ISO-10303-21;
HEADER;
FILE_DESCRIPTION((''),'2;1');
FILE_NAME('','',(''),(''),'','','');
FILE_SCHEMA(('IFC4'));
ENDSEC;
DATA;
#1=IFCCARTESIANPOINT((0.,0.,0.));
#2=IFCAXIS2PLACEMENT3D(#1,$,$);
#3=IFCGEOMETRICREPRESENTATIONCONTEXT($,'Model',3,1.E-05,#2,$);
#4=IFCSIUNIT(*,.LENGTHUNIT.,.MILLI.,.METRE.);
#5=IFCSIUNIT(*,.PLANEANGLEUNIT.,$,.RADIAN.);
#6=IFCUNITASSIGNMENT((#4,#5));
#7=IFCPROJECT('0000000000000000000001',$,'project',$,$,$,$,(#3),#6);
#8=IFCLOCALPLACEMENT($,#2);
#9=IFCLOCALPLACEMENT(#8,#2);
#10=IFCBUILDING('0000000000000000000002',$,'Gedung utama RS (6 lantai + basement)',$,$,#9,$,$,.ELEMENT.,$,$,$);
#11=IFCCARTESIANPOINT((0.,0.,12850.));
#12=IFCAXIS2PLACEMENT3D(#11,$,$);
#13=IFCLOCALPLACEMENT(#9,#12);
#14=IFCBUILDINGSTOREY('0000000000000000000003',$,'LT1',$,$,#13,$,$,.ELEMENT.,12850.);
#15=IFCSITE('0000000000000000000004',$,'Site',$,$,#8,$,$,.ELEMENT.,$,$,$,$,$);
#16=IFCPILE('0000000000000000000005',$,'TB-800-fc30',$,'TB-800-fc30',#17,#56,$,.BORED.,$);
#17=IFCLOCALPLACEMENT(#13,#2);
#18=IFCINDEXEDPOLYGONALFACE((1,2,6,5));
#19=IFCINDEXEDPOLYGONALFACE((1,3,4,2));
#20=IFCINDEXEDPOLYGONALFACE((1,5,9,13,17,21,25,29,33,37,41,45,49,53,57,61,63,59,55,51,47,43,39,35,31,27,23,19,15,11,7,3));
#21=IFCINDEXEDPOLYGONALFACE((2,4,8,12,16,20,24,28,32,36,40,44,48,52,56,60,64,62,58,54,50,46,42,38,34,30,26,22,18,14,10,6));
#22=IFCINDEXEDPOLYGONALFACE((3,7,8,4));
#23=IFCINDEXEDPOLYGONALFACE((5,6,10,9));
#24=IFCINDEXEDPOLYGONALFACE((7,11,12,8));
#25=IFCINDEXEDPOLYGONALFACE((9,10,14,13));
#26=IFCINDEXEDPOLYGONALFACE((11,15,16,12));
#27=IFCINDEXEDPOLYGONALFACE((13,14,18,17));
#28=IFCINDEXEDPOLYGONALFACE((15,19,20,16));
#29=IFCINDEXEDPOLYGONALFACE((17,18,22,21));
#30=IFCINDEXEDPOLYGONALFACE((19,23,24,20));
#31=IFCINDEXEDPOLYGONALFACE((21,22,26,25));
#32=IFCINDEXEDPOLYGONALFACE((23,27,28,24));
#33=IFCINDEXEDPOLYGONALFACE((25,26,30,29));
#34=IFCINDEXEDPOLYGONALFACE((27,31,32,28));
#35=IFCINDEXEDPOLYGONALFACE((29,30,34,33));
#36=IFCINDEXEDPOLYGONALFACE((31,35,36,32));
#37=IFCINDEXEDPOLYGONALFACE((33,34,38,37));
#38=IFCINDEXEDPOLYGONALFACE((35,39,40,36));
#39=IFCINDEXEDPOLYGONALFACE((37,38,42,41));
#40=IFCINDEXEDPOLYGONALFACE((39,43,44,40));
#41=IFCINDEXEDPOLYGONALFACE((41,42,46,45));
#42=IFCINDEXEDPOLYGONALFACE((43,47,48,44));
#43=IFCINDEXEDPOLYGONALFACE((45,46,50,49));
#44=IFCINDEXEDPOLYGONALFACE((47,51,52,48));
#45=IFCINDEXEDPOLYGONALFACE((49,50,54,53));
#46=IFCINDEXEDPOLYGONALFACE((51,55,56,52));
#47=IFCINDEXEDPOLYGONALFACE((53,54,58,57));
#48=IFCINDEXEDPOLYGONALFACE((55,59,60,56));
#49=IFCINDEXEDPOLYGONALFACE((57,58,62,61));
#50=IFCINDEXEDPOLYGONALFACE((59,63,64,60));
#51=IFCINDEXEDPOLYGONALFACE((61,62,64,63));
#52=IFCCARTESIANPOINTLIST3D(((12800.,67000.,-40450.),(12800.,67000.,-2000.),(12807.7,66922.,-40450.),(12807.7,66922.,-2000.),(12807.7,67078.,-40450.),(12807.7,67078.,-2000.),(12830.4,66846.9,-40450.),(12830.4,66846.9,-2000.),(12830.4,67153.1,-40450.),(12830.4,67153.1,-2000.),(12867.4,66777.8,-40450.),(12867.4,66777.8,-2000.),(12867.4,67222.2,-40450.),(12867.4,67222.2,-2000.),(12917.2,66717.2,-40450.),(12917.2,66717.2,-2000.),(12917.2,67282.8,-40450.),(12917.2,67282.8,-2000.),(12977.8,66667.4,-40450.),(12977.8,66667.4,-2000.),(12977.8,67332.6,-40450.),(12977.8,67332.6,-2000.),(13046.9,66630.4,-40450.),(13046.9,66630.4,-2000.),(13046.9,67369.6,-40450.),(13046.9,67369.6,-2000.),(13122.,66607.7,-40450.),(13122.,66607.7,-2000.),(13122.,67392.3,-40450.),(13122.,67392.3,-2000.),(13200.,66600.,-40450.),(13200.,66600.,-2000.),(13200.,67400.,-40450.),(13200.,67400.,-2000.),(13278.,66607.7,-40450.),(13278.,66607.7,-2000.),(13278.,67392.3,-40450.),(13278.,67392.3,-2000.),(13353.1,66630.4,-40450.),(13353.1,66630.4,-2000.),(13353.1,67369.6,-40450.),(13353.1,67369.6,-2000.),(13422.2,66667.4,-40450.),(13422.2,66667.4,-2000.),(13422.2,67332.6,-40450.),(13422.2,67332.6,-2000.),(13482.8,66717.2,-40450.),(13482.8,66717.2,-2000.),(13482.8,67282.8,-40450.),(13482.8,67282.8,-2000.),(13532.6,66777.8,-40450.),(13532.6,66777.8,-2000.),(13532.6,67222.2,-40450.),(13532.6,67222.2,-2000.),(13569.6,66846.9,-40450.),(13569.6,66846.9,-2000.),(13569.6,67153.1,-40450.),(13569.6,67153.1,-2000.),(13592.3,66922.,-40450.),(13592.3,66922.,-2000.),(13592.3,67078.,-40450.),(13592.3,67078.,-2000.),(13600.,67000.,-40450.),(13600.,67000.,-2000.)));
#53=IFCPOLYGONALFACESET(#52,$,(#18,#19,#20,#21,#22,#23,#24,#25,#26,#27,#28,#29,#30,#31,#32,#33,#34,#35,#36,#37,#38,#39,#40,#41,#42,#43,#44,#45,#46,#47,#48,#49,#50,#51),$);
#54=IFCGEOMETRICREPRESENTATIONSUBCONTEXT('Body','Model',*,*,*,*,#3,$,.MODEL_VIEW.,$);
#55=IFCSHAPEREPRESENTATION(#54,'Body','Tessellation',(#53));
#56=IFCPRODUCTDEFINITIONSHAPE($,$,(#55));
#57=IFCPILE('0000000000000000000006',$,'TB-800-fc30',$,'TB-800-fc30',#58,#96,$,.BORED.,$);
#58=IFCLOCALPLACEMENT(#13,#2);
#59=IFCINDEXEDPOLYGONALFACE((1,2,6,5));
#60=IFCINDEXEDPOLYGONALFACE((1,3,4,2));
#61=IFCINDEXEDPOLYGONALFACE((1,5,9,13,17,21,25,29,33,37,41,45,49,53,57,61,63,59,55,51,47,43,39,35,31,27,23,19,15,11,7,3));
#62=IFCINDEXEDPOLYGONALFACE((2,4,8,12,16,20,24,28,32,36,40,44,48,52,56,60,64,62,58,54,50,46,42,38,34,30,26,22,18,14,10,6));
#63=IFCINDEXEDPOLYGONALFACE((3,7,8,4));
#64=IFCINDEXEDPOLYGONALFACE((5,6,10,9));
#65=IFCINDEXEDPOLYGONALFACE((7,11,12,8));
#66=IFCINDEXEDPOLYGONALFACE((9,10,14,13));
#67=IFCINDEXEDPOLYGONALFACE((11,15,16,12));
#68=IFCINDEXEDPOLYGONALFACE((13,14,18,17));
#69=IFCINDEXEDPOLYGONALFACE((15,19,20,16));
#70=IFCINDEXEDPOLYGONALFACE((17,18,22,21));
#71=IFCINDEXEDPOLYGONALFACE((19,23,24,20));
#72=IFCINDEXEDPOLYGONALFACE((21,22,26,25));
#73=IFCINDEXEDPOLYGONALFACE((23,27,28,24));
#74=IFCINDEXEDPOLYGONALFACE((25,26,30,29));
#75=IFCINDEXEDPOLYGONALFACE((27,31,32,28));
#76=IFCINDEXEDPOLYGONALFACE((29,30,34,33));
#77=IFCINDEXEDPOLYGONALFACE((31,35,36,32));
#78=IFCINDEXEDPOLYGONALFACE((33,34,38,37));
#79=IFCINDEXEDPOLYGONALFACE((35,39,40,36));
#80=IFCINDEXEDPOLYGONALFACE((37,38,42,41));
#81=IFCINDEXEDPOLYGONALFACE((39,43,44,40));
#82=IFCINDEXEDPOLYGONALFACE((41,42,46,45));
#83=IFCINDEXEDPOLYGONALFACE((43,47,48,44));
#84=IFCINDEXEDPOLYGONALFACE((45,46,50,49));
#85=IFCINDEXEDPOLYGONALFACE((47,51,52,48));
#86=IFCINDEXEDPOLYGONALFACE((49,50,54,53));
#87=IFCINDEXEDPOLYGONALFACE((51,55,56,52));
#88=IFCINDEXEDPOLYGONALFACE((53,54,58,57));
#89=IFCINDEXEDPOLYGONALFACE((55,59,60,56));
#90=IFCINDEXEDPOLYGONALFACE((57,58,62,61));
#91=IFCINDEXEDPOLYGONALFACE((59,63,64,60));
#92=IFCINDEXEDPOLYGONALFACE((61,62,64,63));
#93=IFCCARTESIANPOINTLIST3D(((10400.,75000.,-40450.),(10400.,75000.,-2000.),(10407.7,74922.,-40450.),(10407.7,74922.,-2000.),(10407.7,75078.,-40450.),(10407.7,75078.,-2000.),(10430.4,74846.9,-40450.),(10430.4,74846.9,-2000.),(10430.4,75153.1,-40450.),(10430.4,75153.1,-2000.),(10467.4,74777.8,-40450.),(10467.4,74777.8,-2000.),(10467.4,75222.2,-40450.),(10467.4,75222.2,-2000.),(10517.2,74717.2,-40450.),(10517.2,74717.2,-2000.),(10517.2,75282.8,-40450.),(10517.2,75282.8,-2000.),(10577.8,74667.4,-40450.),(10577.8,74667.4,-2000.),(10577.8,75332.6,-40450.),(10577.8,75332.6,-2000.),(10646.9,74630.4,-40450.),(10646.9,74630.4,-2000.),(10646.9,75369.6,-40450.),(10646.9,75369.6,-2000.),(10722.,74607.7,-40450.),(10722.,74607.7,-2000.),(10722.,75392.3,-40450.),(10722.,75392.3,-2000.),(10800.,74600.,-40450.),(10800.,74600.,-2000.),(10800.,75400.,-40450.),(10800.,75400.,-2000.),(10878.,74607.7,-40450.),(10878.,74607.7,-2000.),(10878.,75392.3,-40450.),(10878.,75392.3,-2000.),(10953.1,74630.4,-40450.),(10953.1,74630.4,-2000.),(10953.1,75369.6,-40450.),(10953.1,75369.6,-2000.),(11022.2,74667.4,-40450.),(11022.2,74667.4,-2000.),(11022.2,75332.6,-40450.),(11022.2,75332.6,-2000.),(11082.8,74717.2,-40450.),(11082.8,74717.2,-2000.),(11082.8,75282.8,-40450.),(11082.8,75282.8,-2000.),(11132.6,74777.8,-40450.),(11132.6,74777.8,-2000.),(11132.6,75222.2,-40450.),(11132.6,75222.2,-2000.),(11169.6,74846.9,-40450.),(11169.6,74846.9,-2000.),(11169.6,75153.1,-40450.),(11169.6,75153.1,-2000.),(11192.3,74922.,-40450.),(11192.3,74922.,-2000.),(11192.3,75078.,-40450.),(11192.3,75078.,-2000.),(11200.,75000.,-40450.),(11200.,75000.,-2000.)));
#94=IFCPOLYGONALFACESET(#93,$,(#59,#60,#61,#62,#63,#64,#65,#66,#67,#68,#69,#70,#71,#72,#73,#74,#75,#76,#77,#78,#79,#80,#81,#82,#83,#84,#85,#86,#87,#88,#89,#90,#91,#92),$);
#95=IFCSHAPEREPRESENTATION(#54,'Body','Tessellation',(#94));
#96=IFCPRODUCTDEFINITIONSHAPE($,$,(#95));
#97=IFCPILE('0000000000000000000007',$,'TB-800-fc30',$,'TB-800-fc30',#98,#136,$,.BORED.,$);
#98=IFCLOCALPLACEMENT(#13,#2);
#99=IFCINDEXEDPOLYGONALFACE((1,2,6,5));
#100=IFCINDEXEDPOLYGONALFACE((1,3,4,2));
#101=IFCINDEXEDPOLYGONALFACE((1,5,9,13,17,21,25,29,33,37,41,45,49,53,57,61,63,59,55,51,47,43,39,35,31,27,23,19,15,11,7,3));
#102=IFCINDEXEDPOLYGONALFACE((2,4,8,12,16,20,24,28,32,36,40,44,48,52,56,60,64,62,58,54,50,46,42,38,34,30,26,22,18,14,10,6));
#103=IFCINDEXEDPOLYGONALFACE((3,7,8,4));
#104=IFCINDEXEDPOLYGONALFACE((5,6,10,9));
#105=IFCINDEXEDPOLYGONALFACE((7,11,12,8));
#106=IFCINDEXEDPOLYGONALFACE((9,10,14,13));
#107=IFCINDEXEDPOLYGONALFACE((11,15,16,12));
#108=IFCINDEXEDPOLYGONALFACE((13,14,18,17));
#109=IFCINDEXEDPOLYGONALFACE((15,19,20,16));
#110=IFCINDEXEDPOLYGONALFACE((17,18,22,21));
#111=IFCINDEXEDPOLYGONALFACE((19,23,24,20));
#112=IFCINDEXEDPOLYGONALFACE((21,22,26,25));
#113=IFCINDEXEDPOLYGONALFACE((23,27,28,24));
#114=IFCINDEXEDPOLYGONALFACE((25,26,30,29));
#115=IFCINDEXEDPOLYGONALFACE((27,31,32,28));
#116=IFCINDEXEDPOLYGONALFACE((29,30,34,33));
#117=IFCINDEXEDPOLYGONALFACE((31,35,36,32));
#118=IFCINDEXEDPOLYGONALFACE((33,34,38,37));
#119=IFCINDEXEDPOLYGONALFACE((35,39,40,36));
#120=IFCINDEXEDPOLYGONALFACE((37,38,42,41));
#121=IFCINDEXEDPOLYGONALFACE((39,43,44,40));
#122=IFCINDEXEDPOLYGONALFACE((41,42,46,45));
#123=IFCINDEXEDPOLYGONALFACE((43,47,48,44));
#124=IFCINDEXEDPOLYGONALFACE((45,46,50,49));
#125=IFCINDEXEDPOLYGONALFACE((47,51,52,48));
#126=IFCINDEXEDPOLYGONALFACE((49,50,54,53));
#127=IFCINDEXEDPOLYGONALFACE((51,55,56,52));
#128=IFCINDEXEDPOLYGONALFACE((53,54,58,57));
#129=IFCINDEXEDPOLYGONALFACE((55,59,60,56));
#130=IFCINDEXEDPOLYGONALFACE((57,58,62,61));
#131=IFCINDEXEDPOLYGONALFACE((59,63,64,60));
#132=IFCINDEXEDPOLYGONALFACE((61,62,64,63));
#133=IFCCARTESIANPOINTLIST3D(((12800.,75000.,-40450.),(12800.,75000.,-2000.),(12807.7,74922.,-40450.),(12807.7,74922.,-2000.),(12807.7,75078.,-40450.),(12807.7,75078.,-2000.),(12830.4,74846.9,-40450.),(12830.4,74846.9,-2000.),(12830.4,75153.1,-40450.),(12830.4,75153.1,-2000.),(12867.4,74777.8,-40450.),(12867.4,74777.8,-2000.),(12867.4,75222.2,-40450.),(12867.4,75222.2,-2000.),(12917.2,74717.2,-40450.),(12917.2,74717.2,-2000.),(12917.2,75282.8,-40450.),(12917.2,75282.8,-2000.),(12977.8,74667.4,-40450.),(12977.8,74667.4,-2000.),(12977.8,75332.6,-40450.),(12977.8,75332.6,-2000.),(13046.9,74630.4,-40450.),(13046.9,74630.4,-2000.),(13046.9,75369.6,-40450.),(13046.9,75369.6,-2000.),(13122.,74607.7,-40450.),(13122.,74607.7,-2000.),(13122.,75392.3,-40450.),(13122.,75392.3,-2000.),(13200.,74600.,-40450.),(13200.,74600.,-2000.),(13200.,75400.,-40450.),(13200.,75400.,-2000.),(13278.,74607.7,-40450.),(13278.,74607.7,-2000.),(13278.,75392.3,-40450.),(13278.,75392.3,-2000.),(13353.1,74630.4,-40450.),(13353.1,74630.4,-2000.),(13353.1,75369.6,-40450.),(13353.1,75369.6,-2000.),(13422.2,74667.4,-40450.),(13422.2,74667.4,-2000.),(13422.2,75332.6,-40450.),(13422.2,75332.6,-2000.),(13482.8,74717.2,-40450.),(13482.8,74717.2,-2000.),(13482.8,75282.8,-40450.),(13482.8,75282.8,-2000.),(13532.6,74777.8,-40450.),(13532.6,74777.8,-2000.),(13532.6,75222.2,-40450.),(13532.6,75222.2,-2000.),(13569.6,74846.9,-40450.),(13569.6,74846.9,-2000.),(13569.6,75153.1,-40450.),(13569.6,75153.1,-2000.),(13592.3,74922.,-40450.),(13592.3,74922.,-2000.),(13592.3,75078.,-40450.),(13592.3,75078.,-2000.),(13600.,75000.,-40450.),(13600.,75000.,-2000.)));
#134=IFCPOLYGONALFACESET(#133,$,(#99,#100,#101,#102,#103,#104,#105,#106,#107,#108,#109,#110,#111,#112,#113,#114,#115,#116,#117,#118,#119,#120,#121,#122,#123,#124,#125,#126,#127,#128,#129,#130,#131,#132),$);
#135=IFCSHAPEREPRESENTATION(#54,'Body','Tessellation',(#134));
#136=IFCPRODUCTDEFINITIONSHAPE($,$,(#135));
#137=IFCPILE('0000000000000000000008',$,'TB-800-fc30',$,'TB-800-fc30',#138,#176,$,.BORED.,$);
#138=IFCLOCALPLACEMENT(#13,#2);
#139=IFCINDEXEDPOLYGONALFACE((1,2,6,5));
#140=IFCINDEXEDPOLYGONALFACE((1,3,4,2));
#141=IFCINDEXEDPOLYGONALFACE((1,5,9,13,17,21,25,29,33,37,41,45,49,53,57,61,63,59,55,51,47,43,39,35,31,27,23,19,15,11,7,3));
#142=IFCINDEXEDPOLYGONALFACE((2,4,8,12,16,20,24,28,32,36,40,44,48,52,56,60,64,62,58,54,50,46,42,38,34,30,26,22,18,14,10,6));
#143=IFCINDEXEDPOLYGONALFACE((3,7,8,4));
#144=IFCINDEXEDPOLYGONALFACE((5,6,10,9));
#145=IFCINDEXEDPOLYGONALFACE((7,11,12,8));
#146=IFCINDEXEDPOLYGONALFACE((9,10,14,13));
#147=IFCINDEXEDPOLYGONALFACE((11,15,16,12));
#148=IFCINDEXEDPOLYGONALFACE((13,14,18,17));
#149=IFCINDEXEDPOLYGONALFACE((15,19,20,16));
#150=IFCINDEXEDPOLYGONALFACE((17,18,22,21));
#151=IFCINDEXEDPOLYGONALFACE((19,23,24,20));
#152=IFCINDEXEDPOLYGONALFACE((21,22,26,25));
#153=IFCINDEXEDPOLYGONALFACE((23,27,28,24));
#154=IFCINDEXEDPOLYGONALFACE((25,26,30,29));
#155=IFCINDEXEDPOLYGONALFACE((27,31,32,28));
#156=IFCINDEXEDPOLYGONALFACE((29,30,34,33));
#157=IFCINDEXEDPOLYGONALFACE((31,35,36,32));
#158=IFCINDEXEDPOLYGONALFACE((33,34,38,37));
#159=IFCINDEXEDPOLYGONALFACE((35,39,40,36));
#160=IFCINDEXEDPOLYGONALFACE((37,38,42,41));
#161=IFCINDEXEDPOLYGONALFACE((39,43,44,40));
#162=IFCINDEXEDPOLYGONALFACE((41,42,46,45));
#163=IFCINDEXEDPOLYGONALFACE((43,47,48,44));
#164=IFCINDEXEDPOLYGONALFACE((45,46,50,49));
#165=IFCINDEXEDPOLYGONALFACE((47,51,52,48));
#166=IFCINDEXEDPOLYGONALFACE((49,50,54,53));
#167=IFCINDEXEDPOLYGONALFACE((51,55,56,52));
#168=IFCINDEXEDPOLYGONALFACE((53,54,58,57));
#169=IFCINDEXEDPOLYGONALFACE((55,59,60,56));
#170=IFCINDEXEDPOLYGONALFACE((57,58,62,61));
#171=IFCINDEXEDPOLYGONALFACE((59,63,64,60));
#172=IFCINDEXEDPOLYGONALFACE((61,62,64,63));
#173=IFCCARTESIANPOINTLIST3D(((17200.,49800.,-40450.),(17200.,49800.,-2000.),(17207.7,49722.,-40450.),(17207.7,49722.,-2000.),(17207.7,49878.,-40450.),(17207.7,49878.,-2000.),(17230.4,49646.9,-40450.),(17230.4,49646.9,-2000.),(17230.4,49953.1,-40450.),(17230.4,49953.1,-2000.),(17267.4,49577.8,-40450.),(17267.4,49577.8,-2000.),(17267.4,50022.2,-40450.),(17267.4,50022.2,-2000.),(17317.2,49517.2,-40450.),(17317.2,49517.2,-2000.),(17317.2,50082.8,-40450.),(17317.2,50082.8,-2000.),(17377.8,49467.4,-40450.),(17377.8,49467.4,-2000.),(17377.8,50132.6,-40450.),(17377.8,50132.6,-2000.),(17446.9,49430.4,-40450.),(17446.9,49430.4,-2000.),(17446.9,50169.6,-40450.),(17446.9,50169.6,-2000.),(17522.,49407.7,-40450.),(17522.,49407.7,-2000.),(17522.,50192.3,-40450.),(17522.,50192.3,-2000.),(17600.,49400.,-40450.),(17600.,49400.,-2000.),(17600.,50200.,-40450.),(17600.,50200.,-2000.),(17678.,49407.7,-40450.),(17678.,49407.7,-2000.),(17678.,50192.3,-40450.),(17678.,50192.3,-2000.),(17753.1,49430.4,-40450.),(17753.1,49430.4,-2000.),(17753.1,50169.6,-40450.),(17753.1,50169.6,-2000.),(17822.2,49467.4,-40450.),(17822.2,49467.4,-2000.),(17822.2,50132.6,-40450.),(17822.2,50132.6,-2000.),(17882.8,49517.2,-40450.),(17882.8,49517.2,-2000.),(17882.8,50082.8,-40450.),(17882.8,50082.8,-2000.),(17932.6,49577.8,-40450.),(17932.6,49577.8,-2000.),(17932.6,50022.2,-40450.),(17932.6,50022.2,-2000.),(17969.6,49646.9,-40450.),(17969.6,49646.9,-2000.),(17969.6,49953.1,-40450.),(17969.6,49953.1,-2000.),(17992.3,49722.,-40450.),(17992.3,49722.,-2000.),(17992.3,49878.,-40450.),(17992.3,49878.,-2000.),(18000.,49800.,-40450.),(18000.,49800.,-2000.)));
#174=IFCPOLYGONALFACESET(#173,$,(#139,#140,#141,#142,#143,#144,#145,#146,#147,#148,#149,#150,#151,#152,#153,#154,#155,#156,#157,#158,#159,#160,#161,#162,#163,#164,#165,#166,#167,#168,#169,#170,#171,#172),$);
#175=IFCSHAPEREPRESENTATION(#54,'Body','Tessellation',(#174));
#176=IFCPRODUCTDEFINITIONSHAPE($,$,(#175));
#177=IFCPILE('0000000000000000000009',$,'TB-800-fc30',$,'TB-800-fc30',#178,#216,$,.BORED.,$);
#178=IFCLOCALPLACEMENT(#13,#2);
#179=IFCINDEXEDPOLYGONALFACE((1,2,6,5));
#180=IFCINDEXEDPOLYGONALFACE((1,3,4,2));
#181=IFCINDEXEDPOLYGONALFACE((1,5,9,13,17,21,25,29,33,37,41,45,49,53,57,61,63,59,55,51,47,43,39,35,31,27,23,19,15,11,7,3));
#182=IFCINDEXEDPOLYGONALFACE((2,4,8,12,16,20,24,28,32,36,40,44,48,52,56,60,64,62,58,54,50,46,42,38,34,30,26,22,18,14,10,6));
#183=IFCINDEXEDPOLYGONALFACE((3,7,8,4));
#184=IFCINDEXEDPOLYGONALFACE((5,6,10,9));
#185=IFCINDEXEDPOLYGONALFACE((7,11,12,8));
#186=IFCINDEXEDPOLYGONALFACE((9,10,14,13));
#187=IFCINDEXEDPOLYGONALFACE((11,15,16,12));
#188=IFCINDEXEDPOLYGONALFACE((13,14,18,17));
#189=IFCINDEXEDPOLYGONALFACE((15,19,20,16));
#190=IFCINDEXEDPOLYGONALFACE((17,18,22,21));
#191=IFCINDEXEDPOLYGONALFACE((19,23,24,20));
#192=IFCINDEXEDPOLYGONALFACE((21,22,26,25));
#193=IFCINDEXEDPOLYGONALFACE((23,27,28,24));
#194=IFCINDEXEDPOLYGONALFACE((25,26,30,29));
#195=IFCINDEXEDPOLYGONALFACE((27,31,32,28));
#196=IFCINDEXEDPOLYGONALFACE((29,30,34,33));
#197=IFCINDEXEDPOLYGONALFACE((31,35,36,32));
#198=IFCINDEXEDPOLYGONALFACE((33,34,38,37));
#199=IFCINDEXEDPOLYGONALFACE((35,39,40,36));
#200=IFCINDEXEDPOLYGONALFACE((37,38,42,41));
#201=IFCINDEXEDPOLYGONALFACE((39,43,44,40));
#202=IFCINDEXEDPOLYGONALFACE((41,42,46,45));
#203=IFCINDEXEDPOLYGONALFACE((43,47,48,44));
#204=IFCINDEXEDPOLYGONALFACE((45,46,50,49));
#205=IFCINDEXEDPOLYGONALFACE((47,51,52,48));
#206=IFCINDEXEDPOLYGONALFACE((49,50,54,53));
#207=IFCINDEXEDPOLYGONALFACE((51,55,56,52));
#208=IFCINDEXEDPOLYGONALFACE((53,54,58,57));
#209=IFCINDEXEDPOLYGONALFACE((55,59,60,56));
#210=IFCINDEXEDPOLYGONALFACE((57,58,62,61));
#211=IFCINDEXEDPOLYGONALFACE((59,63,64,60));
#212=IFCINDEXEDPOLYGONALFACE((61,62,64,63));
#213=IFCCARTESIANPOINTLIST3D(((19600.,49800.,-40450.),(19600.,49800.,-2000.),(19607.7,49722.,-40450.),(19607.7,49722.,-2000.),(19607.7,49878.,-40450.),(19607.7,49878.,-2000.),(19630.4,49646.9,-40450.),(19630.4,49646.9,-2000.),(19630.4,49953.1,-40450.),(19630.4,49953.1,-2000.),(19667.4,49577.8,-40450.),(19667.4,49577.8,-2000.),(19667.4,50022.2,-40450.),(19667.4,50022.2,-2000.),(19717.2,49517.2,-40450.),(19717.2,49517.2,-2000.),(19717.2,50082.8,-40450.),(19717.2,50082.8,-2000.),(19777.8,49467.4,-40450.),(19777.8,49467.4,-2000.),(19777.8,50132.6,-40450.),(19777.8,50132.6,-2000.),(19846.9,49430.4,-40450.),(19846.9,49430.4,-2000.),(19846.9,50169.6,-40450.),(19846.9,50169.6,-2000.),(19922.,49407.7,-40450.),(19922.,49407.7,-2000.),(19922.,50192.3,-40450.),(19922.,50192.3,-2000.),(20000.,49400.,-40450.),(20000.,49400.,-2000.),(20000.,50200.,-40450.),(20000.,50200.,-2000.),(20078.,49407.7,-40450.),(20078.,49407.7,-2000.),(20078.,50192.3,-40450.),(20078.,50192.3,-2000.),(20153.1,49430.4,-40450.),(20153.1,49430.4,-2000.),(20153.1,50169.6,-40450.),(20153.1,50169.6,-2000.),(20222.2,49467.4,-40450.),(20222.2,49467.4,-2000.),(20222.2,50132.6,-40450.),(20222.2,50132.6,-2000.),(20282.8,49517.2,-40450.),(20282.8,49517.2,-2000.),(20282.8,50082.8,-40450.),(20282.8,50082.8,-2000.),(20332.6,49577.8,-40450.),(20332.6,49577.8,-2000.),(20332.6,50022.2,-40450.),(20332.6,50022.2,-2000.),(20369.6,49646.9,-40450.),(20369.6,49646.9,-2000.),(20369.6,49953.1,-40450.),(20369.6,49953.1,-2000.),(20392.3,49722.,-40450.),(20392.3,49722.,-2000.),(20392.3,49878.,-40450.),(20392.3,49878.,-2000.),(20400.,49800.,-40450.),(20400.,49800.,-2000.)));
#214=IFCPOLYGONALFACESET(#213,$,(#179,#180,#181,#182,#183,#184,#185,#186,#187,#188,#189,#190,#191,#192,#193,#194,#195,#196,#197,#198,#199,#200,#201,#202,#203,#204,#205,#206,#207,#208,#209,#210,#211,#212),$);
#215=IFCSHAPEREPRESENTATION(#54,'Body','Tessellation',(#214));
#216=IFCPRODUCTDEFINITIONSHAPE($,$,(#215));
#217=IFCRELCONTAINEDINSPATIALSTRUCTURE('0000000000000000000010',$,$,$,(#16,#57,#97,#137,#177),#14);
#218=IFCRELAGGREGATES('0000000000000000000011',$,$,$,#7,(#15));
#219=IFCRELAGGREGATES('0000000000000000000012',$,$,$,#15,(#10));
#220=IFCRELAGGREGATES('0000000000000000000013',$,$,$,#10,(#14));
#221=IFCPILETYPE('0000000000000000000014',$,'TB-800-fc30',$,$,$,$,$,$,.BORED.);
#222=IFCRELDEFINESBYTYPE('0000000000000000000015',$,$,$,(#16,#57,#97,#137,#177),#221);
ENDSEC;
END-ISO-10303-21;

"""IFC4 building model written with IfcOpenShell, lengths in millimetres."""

from ifc_helpers import new_model, si_unit, frame, origin, origin_2d, place, context, subcontext, project, spatial, circle, extrude, material_profile, profile_set, profile_usage, type_object, element, save


model = new_model("IFC4")

# Units and contexts
model_context = context("Model", 3, precision=1e-05, world=origin())
body_context = subcontext(model_context, "Body", "Model", "MODEL_VIEW")
ifc_project = project(units=[si_unit("LENGTHUNIT", "METRE", prefix="MILLI"), si_unit("PLANEANGLEUNIT", "RADIAN")], contexts=[model_context])

# Site, building, storey
site_placement = place(None, origin())
site = spatial("IfcSite", under=ifc_project, at=site_placement, Name="Site", CompositionType="ELEMENT")
building_placement = place(site_placement, origin())
building = spatial("IfcBuilding", under=site, at=building_placement, Name="Gedung utama RS (6 lantai + basement)", CompositionType="ELEMENT")
storey_placement = place(building_placement, frame((0.0, 0.0, 12850.0)))
storey = spatial("IfcBuildingStorey", under=building, at=storey_placement, Name="LT1", CompositionType="ELEMENT", Elevation=12850.0)

# Piles
ifc_material_profile = material_profile(None, circle(Radius=400.0, at=origin_2d()), Name="TB-800-fc30")
ifc_profile_set = profile_set([ifc_material_profile], Name="TB-800-fc30")
ifc_profile_usage = profile_usage(ifc_profile_set, cardinal=5)
pile_type = type_object("IfcPileType", Name="TB-800-fc30", PredefinedType="BORED", material=ifc_profile_set)
for number, where, z_axis, x_axis, name in (
    (1, (13200.0, 67000.0, -40450.0), (0.0, 0.0, 1.0), (1.0, 0.0, 0.0), "TB-800-fc30"),
    (2, (10800.0, 75000.0, -40450.0), (0.0, 0.0, 1.0), (1.0, 0.0, 0.0), "TB-800-fc30"),
    (3, (13200.0, 75000.0, -40450.0), (0.0, 0.0, 1.0), (1.0, 0.0, 0.0), "TB-800-fc30"),
    (4, (17600.0, 49800.0, -40450.0), (0.0, 0.0, 1.0), (1.0, 0.0, 0.0), "TB-800-fc30"),
    (5, (20000.0, 49800.0, -40450.0), (0.0, 0.0, 1.0), (1.0, 0.0, 0.0), "TB-800-fc30"),
):
    element("IfcPile", number, at=place(storey_placement, frame(where, z_axis=z_axis, x_axis=x_axis)), inside=storey, type_object=pile_type, material=ifc_profile_usage, Name=name, ObjectType="TB-800-fc30", PredefinedType="BORED", context=body_context, shape_type="SweptSolid", body=[
        extrude(circle(Radius=400.0, at=origin_2d()), origin(), (0.0, 0.0, 1.0), 38450.0),
    ])

save(model, "model.ifc")
